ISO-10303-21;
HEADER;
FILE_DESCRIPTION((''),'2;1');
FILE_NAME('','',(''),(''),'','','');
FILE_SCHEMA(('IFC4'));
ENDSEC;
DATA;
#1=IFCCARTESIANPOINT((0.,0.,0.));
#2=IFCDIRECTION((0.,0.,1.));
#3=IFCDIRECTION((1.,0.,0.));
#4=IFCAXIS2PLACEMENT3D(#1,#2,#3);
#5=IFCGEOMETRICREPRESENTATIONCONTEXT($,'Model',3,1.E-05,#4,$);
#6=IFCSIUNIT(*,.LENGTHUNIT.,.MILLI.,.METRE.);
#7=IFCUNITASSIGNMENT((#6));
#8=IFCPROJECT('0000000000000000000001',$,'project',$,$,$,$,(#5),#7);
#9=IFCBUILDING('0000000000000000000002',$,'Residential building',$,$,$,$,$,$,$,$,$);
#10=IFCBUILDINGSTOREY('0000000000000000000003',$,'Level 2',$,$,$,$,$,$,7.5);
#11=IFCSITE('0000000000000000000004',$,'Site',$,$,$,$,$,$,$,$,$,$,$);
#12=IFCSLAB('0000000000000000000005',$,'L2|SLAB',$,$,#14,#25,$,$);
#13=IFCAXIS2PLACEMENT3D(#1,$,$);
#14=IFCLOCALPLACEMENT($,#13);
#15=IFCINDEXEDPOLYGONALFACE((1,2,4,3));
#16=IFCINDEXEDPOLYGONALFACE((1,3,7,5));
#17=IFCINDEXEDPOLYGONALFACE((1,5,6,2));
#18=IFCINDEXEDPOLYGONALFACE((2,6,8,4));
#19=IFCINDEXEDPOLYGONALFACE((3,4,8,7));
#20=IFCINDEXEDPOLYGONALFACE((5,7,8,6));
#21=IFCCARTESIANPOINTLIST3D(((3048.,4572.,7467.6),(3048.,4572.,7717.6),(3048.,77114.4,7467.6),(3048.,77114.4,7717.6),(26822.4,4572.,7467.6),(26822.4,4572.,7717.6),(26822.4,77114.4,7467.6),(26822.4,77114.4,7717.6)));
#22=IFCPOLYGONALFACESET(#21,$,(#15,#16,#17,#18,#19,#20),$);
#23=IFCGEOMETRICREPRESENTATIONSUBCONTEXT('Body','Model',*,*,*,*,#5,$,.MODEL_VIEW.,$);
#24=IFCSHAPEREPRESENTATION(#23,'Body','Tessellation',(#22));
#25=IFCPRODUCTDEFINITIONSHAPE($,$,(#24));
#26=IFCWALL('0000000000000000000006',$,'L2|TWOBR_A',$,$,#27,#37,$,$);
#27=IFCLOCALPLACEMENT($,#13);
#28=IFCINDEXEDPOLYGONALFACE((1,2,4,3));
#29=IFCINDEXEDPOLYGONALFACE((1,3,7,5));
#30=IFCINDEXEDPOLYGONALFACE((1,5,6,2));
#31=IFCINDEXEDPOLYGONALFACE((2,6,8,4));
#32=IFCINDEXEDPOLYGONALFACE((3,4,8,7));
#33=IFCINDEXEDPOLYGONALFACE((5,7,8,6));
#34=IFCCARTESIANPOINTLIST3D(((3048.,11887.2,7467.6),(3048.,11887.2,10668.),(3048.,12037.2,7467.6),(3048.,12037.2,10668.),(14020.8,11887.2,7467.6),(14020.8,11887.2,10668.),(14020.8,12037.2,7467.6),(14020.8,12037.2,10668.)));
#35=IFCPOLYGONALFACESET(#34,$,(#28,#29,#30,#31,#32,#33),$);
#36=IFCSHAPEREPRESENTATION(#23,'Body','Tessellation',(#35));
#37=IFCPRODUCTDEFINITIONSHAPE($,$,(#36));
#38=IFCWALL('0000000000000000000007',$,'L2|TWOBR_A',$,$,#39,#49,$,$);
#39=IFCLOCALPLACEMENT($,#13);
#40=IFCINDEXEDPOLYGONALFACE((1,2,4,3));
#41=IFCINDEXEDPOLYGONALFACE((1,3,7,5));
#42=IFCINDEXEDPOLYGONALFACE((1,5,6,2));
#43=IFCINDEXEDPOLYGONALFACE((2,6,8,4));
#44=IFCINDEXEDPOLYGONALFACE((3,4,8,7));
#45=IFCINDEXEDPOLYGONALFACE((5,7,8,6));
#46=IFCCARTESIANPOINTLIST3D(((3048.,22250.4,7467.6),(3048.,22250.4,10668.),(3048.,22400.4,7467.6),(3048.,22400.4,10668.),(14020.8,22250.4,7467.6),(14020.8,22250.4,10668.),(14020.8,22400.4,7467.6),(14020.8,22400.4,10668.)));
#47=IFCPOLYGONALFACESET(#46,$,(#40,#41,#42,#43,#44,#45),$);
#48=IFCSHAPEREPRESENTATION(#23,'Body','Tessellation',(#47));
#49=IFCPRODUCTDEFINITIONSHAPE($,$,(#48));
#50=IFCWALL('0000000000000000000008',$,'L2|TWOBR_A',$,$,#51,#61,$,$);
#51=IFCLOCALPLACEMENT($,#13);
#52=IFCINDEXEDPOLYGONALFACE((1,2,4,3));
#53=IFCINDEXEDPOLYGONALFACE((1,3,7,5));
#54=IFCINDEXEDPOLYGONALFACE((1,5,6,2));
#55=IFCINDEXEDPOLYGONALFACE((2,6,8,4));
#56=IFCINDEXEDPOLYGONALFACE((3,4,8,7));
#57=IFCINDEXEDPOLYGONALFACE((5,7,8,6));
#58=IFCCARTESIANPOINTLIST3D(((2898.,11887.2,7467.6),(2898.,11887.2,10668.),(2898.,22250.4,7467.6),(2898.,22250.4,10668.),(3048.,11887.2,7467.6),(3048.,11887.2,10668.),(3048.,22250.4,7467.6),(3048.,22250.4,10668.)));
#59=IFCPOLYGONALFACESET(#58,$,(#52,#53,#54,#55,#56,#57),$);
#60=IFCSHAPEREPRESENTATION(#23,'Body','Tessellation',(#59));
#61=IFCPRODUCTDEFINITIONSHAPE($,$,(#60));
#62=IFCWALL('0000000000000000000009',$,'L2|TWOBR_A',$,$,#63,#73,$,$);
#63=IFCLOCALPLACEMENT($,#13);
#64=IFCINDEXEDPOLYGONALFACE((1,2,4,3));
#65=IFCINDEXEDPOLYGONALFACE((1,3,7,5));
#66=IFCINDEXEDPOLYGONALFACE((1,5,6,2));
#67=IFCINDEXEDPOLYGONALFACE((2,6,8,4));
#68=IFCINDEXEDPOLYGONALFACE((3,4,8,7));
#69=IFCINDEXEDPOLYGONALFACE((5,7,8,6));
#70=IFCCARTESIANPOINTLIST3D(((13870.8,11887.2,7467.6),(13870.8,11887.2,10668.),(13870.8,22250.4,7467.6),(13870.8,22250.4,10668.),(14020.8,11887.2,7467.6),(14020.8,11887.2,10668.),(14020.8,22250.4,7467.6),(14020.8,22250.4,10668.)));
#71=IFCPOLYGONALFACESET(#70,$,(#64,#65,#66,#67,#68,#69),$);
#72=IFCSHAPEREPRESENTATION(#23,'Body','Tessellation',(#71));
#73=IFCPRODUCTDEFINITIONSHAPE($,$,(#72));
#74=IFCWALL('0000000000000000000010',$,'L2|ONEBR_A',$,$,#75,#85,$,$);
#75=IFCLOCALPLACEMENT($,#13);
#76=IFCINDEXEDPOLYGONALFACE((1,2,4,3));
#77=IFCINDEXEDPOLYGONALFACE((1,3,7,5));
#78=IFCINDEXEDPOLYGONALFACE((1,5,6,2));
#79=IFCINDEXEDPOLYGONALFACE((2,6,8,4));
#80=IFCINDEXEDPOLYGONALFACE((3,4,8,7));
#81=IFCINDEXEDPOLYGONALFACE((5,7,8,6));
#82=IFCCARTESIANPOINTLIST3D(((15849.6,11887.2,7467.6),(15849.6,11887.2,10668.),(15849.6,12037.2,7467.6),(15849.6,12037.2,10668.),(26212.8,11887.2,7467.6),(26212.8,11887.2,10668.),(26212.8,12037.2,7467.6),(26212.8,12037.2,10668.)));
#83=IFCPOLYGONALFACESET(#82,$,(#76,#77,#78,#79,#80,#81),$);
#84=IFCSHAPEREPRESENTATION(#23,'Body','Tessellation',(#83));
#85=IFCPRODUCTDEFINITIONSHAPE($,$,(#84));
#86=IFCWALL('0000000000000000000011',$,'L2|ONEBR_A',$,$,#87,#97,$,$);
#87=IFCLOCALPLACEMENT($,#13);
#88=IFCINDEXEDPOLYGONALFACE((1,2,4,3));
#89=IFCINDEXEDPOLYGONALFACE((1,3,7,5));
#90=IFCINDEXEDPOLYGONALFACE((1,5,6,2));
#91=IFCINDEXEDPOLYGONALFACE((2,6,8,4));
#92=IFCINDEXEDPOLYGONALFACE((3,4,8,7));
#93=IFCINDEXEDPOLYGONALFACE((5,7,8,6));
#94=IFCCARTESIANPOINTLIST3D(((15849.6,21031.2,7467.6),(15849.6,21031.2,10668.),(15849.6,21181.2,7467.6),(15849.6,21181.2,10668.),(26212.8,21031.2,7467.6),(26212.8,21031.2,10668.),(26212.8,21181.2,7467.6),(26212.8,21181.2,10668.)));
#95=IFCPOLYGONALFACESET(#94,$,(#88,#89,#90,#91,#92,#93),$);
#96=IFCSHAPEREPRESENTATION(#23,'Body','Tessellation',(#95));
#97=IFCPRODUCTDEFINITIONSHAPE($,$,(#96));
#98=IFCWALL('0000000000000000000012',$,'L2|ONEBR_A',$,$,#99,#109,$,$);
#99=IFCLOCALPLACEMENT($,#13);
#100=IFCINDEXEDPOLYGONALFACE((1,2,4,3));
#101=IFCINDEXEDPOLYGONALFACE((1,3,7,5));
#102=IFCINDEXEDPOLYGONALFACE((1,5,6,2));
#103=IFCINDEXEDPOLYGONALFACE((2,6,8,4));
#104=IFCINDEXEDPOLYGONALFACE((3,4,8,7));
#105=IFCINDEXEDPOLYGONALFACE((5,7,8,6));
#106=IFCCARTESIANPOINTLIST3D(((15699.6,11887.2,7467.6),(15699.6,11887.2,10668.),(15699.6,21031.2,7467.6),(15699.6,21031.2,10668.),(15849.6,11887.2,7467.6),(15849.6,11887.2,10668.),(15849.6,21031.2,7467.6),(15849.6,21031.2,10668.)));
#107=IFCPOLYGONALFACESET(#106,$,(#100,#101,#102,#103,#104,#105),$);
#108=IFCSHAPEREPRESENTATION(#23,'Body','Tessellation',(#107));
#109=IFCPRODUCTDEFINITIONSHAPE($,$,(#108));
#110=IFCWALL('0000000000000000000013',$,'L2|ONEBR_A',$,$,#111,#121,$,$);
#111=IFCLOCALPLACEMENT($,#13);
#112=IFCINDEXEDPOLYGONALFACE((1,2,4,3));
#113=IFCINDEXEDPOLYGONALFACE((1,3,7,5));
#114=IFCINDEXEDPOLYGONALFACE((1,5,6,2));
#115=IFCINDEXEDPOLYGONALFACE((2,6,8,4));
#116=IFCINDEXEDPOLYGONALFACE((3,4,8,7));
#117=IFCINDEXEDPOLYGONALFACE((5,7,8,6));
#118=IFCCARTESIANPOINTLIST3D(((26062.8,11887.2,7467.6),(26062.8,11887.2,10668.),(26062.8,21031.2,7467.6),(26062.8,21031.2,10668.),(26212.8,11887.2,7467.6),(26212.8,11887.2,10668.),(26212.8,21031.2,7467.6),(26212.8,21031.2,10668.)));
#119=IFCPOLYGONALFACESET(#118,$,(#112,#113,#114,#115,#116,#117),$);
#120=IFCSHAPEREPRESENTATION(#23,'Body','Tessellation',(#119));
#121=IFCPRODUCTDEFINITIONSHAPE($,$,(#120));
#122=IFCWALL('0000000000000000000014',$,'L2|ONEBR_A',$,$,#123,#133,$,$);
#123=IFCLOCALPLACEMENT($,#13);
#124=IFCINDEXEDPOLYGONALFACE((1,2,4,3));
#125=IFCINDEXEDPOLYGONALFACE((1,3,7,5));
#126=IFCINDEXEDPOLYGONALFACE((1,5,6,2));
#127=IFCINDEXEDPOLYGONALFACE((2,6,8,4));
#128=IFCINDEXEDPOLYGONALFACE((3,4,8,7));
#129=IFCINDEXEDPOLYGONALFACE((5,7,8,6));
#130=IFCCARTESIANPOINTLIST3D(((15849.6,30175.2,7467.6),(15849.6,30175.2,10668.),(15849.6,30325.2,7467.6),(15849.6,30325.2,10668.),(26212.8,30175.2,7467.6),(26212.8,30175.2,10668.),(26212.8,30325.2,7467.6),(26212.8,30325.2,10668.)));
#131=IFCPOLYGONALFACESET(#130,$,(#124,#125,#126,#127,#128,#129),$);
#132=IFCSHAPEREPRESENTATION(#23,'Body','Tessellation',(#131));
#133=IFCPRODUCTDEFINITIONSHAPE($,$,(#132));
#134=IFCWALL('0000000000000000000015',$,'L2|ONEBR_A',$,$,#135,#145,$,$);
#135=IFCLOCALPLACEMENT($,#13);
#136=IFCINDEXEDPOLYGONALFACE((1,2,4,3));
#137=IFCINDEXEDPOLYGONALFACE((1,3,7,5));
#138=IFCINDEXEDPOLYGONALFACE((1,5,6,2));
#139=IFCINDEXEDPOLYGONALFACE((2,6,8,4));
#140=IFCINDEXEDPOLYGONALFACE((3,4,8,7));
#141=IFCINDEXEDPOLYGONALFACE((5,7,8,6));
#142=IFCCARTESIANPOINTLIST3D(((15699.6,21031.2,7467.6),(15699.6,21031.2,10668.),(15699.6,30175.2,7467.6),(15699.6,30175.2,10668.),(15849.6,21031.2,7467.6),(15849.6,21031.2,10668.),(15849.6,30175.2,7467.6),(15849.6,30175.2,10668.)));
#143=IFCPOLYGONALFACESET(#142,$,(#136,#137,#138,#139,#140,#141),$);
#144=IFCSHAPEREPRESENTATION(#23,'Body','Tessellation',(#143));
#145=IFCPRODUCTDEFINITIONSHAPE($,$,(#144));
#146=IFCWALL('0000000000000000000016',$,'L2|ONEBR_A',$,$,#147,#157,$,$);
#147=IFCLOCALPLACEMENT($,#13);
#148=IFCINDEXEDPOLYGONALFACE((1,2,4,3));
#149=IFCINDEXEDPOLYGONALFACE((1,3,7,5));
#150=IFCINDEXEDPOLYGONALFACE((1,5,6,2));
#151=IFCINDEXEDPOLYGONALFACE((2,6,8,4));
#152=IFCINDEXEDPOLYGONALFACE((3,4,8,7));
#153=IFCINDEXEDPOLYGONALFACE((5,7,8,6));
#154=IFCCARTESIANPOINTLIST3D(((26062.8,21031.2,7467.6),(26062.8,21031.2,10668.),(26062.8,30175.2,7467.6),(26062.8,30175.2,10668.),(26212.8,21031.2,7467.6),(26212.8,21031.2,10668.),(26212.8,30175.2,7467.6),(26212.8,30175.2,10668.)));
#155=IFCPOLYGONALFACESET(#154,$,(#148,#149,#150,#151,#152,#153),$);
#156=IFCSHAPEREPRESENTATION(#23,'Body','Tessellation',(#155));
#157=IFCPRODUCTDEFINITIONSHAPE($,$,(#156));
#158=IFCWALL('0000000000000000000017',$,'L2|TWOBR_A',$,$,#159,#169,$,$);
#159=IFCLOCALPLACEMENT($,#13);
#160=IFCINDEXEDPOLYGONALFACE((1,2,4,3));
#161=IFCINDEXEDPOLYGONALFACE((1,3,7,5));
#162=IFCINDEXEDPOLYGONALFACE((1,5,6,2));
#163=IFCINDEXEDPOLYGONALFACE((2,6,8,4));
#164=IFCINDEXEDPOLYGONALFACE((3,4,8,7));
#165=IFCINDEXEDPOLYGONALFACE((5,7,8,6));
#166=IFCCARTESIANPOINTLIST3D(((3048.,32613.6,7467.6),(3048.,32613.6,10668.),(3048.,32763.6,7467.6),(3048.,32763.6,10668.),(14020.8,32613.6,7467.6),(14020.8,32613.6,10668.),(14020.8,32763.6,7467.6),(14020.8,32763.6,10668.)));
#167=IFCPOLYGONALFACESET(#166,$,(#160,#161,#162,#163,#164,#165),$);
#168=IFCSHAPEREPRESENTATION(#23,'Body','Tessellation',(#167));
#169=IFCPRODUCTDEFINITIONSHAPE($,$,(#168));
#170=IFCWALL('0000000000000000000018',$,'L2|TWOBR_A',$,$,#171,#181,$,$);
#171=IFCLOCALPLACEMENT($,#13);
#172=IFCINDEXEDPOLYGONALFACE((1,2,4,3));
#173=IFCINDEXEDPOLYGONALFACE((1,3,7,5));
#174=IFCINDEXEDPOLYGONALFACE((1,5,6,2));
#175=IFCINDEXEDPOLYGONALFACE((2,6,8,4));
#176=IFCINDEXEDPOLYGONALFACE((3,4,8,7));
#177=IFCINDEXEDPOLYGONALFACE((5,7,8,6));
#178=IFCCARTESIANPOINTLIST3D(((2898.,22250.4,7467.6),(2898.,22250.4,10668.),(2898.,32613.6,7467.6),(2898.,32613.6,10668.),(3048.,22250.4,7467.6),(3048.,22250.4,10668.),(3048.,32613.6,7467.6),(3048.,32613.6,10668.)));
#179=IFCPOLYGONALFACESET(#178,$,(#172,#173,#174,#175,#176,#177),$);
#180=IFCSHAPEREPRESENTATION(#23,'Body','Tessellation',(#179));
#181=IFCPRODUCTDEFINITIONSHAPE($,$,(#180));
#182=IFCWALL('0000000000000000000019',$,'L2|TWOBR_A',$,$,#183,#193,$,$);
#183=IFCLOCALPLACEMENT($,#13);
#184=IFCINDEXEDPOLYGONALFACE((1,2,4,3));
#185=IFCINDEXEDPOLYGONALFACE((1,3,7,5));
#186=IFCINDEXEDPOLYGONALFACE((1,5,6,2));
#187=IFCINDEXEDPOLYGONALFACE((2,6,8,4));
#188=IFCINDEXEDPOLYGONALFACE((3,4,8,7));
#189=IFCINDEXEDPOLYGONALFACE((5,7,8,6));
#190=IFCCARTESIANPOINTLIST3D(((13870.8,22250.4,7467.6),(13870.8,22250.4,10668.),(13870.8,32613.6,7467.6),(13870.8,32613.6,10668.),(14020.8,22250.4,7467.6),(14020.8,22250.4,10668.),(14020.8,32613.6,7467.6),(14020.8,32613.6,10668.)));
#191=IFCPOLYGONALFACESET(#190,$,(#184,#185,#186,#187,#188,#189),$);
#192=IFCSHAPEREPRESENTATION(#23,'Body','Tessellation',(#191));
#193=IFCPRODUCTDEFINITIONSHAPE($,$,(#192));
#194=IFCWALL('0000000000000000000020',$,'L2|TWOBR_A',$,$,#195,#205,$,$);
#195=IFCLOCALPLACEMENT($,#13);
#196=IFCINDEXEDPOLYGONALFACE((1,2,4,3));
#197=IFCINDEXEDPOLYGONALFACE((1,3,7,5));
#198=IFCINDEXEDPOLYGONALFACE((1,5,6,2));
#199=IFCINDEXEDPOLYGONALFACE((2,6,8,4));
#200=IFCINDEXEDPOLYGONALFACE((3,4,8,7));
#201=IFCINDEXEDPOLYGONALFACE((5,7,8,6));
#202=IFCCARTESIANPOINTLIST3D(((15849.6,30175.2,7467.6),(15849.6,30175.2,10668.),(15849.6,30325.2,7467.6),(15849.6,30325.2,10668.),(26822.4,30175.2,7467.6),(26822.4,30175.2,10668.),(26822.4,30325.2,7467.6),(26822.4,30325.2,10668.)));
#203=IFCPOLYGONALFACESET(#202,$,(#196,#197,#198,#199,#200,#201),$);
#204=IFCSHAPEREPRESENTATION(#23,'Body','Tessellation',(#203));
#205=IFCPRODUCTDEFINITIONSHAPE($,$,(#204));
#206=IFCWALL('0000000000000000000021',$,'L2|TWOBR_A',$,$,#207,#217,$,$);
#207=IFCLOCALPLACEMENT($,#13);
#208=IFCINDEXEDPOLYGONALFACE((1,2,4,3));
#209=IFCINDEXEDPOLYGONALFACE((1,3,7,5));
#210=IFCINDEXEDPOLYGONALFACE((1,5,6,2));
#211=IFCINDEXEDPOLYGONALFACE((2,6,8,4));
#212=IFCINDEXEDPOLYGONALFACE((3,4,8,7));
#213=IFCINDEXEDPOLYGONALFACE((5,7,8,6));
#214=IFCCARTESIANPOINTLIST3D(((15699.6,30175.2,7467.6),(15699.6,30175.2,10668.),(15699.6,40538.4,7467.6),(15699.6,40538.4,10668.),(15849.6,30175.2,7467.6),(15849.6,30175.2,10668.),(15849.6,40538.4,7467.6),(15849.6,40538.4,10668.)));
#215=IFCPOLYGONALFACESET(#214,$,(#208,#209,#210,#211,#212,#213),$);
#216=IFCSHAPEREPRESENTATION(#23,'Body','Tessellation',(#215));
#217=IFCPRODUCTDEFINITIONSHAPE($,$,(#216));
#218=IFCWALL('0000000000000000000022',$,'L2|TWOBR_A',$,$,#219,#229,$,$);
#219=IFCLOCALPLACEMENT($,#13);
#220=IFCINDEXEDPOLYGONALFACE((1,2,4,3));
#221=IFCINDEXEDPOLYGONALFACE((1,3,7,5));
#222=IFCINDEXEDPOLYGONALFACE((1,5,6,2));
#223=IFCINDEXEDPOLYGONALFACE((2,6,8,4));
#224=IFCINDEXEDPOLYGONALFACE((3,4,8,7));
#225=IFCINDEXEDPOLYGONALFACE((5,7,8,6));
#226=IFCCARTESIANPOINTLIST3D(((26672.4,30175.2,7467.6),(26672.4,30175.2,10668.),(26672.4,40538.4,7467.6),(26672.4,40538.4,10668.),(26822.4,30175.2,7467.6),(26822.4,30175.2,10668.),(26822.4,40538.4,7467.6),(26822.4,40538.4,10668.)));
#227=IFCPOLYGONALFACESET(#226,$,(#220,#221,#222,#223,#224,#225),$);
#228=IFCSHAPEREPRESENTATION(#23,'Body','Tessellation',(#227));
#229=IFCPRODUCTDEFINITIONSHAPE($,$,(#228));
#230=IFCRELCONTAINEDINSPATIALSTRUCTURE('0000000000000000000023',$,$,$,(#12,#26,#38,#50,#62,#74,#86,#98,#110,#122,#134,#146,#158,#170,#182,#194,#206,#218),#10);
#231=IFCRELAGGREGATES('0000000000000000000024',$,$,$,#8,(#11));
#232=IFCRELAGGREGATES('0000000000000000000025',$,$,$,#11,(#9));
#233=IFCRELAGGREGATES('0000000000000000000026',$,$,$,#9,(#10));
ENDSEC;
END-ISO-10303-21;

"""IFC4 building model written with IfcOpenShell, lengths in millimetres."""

from ifc_helpers import new_model, si_unit, frame, origin_with_axes, place, context, subcontext, project, spatial, indexed_curve, outline, extrude, element, save


model = new_model("IFC4")

# Units and contexts
model_context = context("Model", 3, precision=1e-05, world=origin_with_axes())
body_context = subcontext(model_context, "Body", "Model", "MODEL_VIEW")
ifc_project = project(units=[si_unit("LENGTHUNIT", "METRE", prefix="MILLI")], contexts=[model_context])

# Site, building, storey
site = spatial("IfcSite", under=ifc_project, Name="Site")
building = spatial("IfcBuilding", under=site, Name="Residential building")
storey = spatial("IfcBuildingStorey", under=building, Name="Level 2", Elevation=7.5)

# Slab
slab_placement = place(None, frame((3048.0, 4572.0, 7467.6), z_axis=(0.0, 0.0, 1.0), x_axis=(1.0, 0.0, 0.0)))
element("IfcSlab", 1, at=slab_placement, inside=storey, Name="L2|SLAB", context=body_context, shape_type="SweptSolid", body=[
    extrude(outline(indexed_curve([(0.0, 0.0), (23774.4, 0.0), (23774.4, 72542.4), (0.0, 72542.4), (0.0, 0.0)])), None, (0.0, 0.0, 1.0), 250.0),
])

# Walls
for number, where, z_axis, x_axis, name in (
    (2, (3048.0, 11887.2, 7467.6), (0.0, 0.0, 1.0), (1.0, 0.0, 0.0), "L2|TWOBR_A"),
    (3, (3048.0, 22250.4, 7467.6), (0.0, 0.0, 1.0), (1.0, 0.0, 0.0), "L2|TWOBR_A"),
):
    element("IfcWall", number, at=place(None, frame(where, z_axis=z_axis, x_axis=x_axis)), inside=storey, Name=name, context=body_context, shape_type="SweptSolid", body=[
        extrude(outline(indexed_curve([(0.0, 0.0), (0.0, 150.0), (10972.8, 150.0), (10972.8, 0.0), (0.0, 0.0)], self_intersect=False)), origin_with_axes(), (0.0, 0.0, 1.0), 3200.4),
    ])
for number, where, z_axis, x_axis, name in (
    (4, (3048.0, 11887.2, 7467.6), (0.0, 0.0, 1.0), (0.0, 1.0, 0.0), "L2|TWOBR_A"),
    (5, (14020.8, 11887.2, 7467.6), (0.0, 0.0, 1.0), (0.0, 1.0, 0.0), "L2|TWOBR_A"),
    (6, (15849.6, 11887.2, 7467.6), (0.0, 0.0, 1.0), (1.0, 0.0, 0.0), "L2|ONEBR_A"),
    (7, (15849.6, 21031.2, 7467.6), (0.0, 0.0, 1.0), (1.0, 0.0, 0.0), "L2|ONEBR_A"),
):
    element("IfcWall", number, at=place(None, frame(where, z_axis=z_axis, x_axis=x_axis)), inside=storey, Name=name, context=body_context, shape_type="SweptSolid", body=[
        extrude(outline(indexed_curve([(0.0, 0.0), (0.0, 150.0), (10363.2, 150.0), (10363.2, 0.0), (0.0, 0.0)], self_intersect=False)), origin_with_axes(), (0.0, 0.0, 1.0), 3200.4),
    ])
for number, where, z_axis, x_axis, name in (
    (8, (15849.6, 11887.2, 7467.6), (0.0, 0.0, 1.0), (0.0, 1.0, 0.0), "L2|ONEBR_A"),
    (9, (26212.8, 11887.2, 7467.6), (0.0, 0.0, 1.0), (0.0, 1.0, 0.0), "L2|ONEBR_A"),
):
    element("IfcWall", number, at=place(None, frame(where, z_axis=z_axis, x_axis=x_axis)), inside=storey, Name=name, context=body_context, shape_type="SweptSolid", body=[
        extrude(outline(indexed_curve([(0.0, 0.0), (0.0, 150.0), (9144.0, 150.0), (9144.0, 0.0), (0.0, 0.0)], self_intersect=False)), origin_with_axes(), (0.0, 0.0, 1.0), 3200.4),
    ])
for number, where, z_axis, x_axis, name in (
    (10, (15849.6, 30175.2, 7467.6), (0.0, 0.0, 1.0), (1.0, 0.0, 0.0), "L2|ONEBR_A"),
):
    element("IfcWall", number, at=place(None, frame(where, z_axis=z_axis, x_axis=x_axis)), inside=storey, Name=name, context=body_context, shape_type="SweptSolid", body=[
        extrude(outline(indexed_curve([(0.0, 0.0), (0.0, 150.0), (10363.2, 150.0), (10363.2, 0.0), (0.0, 0.0)], self_intersect=False)), origin_with_axes(), (0.0, 0.0, 1.0), 3200.4),
    ])
for number, where, z_axis, x_axis, name in (
    (11, (15849.6, 21031.2, 7467.6), (0.0, 0.0, 1.0), (0.0, 1.0, 0.0), "L2|ONEBR_A"),
    (12, (26212.8, 21031.2, 7467.6), (0.0, 0.0, 1.0), (0.0, 1.0, 0.0), "L2|ONEBR_A"),
):
    element("IfcWall", number, at=place(None, frame(where, z_axis=z_axis, x_axis=x_axis)), inside=storey, Name=name, context=body_context, shape_type="SweptSolid", body=[
        extrude(outline(indexed_curve([(0.0, 0.0), (0.0, 150.0), (9144.0, 150.0), (9144.0, 0.0), (0.0, 0.0)], self_intersect=False)), origin_with_axes(), (0.0, 0.0, 1.0), 3200.4),
    ])
for number, where, z_axis, x_axis, name in (
    (13, (3048.0, 32613.6, 7467.6), (0.0, 0.0, 1.0), (1.0, 0.0, 0.0), "L2|TWOBR_A"),
):
    element("IfcWall", number, at=place(None, frame(where, z_axis=z_axis, x_axis=x_axis)), inside=storey, Name=name, context=body_context, shape_type="SweptSolid", body=[
        extrude(outline(indexed_curve([(0.0, 0.0), (0.0, 150.0), (10972.8, 150.0), (10972.8, 0.0), (0.0, 0.0)], self_intersect=False)), origin_with_axes(), (0.0, 0.0, 1.0), 3200.4),
    ])
for number, where, z_axis, x_axis, name in (
    (14, (3048.0, 22250.4, 7467.6), (0.0, 0.0, 1.0), (0.0, 1.0, 0.0), "L2|TWOBR_A"),
    (15, (14020.8, 22250.4, 7467.6), (0.0, 0.0, 1.0), (0.0, 1.0, 0.0), "L2|TWOBR_A"),
):
    element("IfcWall", number, at=place(None, frame(where, z_axis=z_axis, x_axis=x_axis)), inside=storey, Name=name, context=body_context, shape_type="SweptSolid", body=[
        extrude(outline(indexed_curve([(0.0, 0.0), (0.0, 150.0), (10363.2, 150.0), (10363.2, 0.0), (0.0, 0.0)], self_intersect=False)), origin_with_axes(), (0.0, 0.0, 1.0), 3200.4),
    ])
wall_1_placement = place(None, frame((15849.6, 30175.2, 7467.6), z_axis=(0.0, 0.0, 1.0), x_axis=(1.0, 0.0, 0.0)))
element("IfcWall", 16, at=wall_1_placement, inside=storey, Name="L2|TWOBR_A", context=body_context, shape_type="SweptSolid", body=[
    extrude(outline(indexed_curve([(0.0, 0.0), (0.0, 150.0), (10972.8, 150.0), (10972.8, 0.0), (0.0, 0.0)], self_intersect=False)), origin_with_axes(), (0.0, 0.0, 1.0), 3200.4),
])
for number, where, z_axis, x_axis, name in (
    (17, (15849.6, 30175.2, 7467.6), (0.0, 0.0, 1.0), (0.0, 1.0, 0.0), "L2|TWOBR_A"),
    (18, (26822.4, 30175.2, 7467.6), (0.0, 0.0, 1.0), (0.0, 1.0, 0.0), "L2|TWOBR_A"),
):
    element("IfcWall", number, at=place(None, frame(where, z_axis=z_axis, x_axis=x_axis)), inside=storey, Name=name, context=body_context, shape_type="SweptSolid", body=[
        extrude(outline(indexed_curve([(0.0, 0.0), (0.0, 150.0), (10363.2, 150.0), (10363.2, 0.0), (0.0, 0.0)], self_intersect=False)), origin_with_axes(), (0.0, 0.0, 1.0), 3200.4),
    ])

save(model, "model.ifc")
